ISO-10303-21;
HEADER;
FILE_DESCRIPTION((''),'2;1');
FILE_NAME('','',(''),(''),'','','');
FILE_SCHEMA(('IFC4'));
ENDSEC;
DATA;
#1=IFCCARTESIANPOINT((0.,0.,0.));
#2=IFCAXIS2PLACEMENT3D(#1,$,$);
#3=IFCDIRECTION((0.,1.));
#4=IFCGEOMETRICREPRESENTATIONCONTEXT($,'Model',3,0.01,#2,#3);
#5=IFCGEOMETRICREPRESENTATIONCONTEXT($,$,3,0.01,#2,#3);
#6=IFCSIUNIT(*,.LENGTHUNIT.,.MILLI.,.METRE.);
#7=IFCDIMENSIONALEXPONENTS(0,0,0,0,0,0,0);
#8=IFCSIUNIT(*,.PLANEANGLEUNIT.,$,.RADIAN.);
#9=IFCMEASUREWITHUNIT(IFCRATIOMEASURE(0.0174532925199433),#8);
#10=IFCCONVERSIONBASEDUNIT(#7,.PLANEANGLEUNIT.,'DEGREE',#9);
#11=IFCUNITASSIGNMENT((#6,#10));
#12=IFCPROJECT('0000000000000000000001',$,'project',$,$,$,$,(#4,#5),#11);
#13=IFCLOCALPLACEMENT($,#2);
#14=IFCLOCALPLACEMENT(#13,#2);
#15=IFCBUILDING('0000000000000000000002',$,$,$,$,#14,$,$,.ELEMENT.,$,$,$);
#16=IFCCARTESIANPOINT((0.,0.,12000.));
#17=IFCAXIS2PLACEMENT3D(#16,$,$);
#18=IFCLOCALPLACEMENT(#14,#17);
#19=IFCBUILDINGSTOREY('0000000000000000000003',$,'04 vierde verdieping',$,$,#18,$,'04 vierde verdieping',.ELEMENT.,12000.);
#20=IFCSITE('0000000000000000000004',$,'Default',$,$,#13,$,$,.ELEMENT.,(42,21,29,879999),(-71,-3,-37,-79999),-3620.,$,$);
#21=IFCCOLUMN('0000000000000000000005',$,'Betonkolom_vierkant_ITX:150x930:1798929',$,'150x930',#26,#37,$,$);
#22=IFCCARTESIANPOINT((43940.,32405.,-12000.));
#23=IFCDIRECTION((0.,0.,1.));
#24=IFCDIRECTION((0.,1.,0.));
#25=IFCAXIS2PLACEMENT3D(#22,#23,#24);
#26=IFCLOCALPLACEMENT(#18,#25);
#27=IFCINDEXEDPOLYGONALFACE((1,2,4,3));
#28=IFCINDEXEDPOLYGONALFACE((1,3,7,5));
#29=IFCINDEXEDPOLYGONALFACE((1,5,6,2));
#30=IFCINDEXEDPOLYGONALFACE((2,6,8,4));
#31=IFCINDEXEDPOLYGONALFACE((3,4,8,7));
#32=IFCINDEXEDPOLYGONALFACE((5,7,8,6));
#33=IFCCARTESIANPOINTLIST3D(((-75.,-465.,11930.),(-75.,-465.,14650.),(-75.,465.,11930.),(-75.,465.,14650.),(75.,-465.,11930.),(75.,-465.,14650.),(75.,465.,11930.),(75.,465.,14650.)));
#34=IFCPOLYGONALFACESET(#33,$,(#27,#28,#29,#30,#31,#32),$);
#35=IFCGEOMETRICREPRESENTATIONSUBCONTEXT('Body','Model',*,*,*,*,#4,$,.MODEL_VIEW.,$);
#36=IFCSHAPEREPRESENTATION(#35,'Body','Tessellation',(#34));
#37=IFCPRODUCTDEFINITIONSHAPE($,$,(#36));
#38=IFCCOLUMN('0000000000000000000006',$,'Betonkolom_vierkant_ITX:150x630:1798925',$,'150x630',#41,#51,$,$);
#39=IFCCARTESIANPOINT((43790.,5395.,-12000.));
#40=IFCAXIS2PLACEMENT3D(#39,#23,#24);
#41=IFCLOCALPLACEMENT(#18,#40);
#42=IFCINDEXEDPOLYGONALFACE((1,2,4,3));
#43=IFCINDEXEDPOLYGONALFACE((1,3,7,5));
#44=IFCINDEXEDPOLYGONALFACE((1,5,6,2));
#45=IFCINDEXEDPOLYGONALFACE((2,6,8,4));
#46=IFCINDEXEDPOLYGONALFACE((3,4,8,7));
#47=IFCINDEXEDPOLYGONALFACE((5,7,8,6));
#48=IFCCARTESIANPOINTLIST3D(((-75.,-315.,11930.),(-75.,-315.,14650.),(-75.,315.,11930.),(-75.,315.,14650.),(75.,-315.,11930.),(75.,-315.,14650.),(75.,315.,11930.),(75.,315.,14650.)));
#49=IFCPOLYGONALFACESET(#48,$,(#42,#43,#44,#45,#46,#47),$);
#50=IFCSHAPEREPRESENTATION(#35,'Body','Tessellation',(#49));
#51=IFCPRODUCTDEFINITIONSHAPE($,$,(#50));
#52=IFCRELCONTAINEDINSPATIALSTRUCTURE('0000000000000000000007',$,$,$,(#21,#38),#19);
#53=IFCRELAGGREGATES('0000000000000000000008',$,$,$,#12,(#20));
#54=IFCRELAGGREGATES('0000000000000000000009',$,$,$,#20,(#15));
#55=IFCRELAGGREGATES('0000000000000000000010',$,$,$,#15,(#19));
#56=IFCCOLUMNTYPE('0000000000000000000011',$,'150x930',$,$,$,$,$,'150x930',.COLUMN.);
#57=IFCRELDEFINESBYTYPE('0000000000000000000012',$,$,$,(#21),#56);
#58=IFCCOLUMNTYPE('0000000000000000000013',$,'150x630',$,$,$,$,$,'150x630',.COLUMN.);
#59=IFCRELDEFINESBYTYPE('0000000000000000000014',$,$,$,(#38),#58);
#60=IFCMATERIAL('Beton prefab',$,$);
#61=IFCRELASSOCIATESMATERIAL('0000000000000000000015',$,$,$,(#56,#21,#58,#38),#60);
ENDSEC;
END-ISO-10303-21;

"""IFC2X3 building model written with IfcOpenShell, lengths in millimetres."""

from ifc_helpers import new_model, entity, si_unit, converted_unit, direction, frame, origin, origin_2d_with_axis, place, context, subcontext, project, spatial, rectangle, extrude, source, transform, mapped, material, type_object, type_shapes, element, save


model = new_model("IFC2X3")

# Units and contexts
model_context = context("Model", 3, precision=0.01, world=origin(), true_north=direction((0.0, 1.0)))
context_of_model = context(None, 3, precision=0.01, world=origin(), true_north=direction((0.0, 1.0)))
body_context = subcontext(model_context, "Body", "Model", "MODEL_VIEW")
ifc_project = project(units=[si_unit("LENGTHUNIT", "METRE", prefix="MILLI"), converted_unit("PLANEANGLEUNIT", "DEGREE", entity("IfcRatioMeasure", 0.0174532925199433), si_unit("PLANEANGLEUNIT", "RADIAN"), dimensions=[0, 0, 0, 0, 0, 0, 0])], contexts=[model_context, context_of_model])

# Site, building, storey
site_placement = place(None, origin())
site = spatial("IfcSite", under=ifc_project, at=site_placement, Name="Default", CompositionType="ELEMENT", RefLatitude=(42, 21, 29, 879999), RefLongitude=(-71, -3, -37, -79999), RefElevation=-3620.0)
building_placement = place(site_placement, origin())
building = spatial("IfcBuilding", under=site, at=building_placement, CompositionType="ELEMENT")
storey_placement = place(building_placement, frame((0.0, 0.0, 12000.0)))
storey = spatial("IfcBuildingStorey", under=building, at=storey_placement, Name="04 vierde verdieping", LongName="04 vierde verdieping", CompositionType="ELEMENT", Elevation=12000.0)

# Columns
ifc_material_1 = material(Name="Beton prefab")
column_type_1 = type_object("IfcColumnType", Name="150x930", ElementType="150x930", PredefinedType="COLUMN", material=ifc_material_1)
shared_shape_1 = source(origin(), body_context, "Body", "SweptSolid", [
    extrude(rectangle(XDim=930.0, YDim=150.0, at=origin_2d_with_axis()), frame((0.0, 0.0, 11930.0), z_axis=(0.0, 0.0, 1.0), x_axis=(0.0, -1.0, 0.0)), (0.0, 0.0, 1.0), 2720.0),
])
type_shapes(column_type_1, [shared_shape_1])
column_1_placement = place(storey_placement, frame((43940.0, 32405.0, -12000.0), z_axis=(0.0, 0.0, 1.0), x_axis=(0.0, 1.0, 0.0)))
element("IfcColumn", 1, at=column_1_placement, inside=storey, type_object=column_type_1, material=ifc_material_1, Name="Betonkolom_vierkant_ITX:150x930:1798929", ObjectType="150x930", context=body_context, shape_type="MappedRepresentation", body=[
    mapped(shared_shape_1, transform((0.0, 0.0, 0.0), scale=1.0)),
])
column_type_2 = type_object("IfcColumnType", Name="150x630", ElementType="150x630", PredefinedType="COLUMN", material=ifc_material_1)
shared_shape_2 = source(origin(), body_context, "Body", "SweptSolid", [
    extrude(rectangle(XDim=630.0, YDim=150.0, at=origin_2d_with_axis()), frame((0.0, 0.0, 11930.0), z_axis=(0.0, 0.0, 1.0), x_axis=(0.0, -1.0, 0.0)), (0.0, 0.0, 1.0), 2720.0),
])
type_shapes(column_type_2, [shared_shape_2])
column_2_placement = place(storey_placement, frame((43790.0, 5395.0, -12000.0), z_axis=(0.0, 0.0, 1.0), x_axis=(0.0, 1.0, 0.0)))
element("IfcColumn", 2, at=column_2_placement, inside=storey, type_object=column_type_2, material=ifc_material_1, Name="Betonkolom_vierkant_ITX:150x630:1798925", ObjectType="150x630", context=body_context, shape_type="MappedRepresentation", body=[
    mapped(shared_shape_2, transform((0.0, 0.0, 0.0), scale=1.0)),
])

save(model, "model.ifc")
